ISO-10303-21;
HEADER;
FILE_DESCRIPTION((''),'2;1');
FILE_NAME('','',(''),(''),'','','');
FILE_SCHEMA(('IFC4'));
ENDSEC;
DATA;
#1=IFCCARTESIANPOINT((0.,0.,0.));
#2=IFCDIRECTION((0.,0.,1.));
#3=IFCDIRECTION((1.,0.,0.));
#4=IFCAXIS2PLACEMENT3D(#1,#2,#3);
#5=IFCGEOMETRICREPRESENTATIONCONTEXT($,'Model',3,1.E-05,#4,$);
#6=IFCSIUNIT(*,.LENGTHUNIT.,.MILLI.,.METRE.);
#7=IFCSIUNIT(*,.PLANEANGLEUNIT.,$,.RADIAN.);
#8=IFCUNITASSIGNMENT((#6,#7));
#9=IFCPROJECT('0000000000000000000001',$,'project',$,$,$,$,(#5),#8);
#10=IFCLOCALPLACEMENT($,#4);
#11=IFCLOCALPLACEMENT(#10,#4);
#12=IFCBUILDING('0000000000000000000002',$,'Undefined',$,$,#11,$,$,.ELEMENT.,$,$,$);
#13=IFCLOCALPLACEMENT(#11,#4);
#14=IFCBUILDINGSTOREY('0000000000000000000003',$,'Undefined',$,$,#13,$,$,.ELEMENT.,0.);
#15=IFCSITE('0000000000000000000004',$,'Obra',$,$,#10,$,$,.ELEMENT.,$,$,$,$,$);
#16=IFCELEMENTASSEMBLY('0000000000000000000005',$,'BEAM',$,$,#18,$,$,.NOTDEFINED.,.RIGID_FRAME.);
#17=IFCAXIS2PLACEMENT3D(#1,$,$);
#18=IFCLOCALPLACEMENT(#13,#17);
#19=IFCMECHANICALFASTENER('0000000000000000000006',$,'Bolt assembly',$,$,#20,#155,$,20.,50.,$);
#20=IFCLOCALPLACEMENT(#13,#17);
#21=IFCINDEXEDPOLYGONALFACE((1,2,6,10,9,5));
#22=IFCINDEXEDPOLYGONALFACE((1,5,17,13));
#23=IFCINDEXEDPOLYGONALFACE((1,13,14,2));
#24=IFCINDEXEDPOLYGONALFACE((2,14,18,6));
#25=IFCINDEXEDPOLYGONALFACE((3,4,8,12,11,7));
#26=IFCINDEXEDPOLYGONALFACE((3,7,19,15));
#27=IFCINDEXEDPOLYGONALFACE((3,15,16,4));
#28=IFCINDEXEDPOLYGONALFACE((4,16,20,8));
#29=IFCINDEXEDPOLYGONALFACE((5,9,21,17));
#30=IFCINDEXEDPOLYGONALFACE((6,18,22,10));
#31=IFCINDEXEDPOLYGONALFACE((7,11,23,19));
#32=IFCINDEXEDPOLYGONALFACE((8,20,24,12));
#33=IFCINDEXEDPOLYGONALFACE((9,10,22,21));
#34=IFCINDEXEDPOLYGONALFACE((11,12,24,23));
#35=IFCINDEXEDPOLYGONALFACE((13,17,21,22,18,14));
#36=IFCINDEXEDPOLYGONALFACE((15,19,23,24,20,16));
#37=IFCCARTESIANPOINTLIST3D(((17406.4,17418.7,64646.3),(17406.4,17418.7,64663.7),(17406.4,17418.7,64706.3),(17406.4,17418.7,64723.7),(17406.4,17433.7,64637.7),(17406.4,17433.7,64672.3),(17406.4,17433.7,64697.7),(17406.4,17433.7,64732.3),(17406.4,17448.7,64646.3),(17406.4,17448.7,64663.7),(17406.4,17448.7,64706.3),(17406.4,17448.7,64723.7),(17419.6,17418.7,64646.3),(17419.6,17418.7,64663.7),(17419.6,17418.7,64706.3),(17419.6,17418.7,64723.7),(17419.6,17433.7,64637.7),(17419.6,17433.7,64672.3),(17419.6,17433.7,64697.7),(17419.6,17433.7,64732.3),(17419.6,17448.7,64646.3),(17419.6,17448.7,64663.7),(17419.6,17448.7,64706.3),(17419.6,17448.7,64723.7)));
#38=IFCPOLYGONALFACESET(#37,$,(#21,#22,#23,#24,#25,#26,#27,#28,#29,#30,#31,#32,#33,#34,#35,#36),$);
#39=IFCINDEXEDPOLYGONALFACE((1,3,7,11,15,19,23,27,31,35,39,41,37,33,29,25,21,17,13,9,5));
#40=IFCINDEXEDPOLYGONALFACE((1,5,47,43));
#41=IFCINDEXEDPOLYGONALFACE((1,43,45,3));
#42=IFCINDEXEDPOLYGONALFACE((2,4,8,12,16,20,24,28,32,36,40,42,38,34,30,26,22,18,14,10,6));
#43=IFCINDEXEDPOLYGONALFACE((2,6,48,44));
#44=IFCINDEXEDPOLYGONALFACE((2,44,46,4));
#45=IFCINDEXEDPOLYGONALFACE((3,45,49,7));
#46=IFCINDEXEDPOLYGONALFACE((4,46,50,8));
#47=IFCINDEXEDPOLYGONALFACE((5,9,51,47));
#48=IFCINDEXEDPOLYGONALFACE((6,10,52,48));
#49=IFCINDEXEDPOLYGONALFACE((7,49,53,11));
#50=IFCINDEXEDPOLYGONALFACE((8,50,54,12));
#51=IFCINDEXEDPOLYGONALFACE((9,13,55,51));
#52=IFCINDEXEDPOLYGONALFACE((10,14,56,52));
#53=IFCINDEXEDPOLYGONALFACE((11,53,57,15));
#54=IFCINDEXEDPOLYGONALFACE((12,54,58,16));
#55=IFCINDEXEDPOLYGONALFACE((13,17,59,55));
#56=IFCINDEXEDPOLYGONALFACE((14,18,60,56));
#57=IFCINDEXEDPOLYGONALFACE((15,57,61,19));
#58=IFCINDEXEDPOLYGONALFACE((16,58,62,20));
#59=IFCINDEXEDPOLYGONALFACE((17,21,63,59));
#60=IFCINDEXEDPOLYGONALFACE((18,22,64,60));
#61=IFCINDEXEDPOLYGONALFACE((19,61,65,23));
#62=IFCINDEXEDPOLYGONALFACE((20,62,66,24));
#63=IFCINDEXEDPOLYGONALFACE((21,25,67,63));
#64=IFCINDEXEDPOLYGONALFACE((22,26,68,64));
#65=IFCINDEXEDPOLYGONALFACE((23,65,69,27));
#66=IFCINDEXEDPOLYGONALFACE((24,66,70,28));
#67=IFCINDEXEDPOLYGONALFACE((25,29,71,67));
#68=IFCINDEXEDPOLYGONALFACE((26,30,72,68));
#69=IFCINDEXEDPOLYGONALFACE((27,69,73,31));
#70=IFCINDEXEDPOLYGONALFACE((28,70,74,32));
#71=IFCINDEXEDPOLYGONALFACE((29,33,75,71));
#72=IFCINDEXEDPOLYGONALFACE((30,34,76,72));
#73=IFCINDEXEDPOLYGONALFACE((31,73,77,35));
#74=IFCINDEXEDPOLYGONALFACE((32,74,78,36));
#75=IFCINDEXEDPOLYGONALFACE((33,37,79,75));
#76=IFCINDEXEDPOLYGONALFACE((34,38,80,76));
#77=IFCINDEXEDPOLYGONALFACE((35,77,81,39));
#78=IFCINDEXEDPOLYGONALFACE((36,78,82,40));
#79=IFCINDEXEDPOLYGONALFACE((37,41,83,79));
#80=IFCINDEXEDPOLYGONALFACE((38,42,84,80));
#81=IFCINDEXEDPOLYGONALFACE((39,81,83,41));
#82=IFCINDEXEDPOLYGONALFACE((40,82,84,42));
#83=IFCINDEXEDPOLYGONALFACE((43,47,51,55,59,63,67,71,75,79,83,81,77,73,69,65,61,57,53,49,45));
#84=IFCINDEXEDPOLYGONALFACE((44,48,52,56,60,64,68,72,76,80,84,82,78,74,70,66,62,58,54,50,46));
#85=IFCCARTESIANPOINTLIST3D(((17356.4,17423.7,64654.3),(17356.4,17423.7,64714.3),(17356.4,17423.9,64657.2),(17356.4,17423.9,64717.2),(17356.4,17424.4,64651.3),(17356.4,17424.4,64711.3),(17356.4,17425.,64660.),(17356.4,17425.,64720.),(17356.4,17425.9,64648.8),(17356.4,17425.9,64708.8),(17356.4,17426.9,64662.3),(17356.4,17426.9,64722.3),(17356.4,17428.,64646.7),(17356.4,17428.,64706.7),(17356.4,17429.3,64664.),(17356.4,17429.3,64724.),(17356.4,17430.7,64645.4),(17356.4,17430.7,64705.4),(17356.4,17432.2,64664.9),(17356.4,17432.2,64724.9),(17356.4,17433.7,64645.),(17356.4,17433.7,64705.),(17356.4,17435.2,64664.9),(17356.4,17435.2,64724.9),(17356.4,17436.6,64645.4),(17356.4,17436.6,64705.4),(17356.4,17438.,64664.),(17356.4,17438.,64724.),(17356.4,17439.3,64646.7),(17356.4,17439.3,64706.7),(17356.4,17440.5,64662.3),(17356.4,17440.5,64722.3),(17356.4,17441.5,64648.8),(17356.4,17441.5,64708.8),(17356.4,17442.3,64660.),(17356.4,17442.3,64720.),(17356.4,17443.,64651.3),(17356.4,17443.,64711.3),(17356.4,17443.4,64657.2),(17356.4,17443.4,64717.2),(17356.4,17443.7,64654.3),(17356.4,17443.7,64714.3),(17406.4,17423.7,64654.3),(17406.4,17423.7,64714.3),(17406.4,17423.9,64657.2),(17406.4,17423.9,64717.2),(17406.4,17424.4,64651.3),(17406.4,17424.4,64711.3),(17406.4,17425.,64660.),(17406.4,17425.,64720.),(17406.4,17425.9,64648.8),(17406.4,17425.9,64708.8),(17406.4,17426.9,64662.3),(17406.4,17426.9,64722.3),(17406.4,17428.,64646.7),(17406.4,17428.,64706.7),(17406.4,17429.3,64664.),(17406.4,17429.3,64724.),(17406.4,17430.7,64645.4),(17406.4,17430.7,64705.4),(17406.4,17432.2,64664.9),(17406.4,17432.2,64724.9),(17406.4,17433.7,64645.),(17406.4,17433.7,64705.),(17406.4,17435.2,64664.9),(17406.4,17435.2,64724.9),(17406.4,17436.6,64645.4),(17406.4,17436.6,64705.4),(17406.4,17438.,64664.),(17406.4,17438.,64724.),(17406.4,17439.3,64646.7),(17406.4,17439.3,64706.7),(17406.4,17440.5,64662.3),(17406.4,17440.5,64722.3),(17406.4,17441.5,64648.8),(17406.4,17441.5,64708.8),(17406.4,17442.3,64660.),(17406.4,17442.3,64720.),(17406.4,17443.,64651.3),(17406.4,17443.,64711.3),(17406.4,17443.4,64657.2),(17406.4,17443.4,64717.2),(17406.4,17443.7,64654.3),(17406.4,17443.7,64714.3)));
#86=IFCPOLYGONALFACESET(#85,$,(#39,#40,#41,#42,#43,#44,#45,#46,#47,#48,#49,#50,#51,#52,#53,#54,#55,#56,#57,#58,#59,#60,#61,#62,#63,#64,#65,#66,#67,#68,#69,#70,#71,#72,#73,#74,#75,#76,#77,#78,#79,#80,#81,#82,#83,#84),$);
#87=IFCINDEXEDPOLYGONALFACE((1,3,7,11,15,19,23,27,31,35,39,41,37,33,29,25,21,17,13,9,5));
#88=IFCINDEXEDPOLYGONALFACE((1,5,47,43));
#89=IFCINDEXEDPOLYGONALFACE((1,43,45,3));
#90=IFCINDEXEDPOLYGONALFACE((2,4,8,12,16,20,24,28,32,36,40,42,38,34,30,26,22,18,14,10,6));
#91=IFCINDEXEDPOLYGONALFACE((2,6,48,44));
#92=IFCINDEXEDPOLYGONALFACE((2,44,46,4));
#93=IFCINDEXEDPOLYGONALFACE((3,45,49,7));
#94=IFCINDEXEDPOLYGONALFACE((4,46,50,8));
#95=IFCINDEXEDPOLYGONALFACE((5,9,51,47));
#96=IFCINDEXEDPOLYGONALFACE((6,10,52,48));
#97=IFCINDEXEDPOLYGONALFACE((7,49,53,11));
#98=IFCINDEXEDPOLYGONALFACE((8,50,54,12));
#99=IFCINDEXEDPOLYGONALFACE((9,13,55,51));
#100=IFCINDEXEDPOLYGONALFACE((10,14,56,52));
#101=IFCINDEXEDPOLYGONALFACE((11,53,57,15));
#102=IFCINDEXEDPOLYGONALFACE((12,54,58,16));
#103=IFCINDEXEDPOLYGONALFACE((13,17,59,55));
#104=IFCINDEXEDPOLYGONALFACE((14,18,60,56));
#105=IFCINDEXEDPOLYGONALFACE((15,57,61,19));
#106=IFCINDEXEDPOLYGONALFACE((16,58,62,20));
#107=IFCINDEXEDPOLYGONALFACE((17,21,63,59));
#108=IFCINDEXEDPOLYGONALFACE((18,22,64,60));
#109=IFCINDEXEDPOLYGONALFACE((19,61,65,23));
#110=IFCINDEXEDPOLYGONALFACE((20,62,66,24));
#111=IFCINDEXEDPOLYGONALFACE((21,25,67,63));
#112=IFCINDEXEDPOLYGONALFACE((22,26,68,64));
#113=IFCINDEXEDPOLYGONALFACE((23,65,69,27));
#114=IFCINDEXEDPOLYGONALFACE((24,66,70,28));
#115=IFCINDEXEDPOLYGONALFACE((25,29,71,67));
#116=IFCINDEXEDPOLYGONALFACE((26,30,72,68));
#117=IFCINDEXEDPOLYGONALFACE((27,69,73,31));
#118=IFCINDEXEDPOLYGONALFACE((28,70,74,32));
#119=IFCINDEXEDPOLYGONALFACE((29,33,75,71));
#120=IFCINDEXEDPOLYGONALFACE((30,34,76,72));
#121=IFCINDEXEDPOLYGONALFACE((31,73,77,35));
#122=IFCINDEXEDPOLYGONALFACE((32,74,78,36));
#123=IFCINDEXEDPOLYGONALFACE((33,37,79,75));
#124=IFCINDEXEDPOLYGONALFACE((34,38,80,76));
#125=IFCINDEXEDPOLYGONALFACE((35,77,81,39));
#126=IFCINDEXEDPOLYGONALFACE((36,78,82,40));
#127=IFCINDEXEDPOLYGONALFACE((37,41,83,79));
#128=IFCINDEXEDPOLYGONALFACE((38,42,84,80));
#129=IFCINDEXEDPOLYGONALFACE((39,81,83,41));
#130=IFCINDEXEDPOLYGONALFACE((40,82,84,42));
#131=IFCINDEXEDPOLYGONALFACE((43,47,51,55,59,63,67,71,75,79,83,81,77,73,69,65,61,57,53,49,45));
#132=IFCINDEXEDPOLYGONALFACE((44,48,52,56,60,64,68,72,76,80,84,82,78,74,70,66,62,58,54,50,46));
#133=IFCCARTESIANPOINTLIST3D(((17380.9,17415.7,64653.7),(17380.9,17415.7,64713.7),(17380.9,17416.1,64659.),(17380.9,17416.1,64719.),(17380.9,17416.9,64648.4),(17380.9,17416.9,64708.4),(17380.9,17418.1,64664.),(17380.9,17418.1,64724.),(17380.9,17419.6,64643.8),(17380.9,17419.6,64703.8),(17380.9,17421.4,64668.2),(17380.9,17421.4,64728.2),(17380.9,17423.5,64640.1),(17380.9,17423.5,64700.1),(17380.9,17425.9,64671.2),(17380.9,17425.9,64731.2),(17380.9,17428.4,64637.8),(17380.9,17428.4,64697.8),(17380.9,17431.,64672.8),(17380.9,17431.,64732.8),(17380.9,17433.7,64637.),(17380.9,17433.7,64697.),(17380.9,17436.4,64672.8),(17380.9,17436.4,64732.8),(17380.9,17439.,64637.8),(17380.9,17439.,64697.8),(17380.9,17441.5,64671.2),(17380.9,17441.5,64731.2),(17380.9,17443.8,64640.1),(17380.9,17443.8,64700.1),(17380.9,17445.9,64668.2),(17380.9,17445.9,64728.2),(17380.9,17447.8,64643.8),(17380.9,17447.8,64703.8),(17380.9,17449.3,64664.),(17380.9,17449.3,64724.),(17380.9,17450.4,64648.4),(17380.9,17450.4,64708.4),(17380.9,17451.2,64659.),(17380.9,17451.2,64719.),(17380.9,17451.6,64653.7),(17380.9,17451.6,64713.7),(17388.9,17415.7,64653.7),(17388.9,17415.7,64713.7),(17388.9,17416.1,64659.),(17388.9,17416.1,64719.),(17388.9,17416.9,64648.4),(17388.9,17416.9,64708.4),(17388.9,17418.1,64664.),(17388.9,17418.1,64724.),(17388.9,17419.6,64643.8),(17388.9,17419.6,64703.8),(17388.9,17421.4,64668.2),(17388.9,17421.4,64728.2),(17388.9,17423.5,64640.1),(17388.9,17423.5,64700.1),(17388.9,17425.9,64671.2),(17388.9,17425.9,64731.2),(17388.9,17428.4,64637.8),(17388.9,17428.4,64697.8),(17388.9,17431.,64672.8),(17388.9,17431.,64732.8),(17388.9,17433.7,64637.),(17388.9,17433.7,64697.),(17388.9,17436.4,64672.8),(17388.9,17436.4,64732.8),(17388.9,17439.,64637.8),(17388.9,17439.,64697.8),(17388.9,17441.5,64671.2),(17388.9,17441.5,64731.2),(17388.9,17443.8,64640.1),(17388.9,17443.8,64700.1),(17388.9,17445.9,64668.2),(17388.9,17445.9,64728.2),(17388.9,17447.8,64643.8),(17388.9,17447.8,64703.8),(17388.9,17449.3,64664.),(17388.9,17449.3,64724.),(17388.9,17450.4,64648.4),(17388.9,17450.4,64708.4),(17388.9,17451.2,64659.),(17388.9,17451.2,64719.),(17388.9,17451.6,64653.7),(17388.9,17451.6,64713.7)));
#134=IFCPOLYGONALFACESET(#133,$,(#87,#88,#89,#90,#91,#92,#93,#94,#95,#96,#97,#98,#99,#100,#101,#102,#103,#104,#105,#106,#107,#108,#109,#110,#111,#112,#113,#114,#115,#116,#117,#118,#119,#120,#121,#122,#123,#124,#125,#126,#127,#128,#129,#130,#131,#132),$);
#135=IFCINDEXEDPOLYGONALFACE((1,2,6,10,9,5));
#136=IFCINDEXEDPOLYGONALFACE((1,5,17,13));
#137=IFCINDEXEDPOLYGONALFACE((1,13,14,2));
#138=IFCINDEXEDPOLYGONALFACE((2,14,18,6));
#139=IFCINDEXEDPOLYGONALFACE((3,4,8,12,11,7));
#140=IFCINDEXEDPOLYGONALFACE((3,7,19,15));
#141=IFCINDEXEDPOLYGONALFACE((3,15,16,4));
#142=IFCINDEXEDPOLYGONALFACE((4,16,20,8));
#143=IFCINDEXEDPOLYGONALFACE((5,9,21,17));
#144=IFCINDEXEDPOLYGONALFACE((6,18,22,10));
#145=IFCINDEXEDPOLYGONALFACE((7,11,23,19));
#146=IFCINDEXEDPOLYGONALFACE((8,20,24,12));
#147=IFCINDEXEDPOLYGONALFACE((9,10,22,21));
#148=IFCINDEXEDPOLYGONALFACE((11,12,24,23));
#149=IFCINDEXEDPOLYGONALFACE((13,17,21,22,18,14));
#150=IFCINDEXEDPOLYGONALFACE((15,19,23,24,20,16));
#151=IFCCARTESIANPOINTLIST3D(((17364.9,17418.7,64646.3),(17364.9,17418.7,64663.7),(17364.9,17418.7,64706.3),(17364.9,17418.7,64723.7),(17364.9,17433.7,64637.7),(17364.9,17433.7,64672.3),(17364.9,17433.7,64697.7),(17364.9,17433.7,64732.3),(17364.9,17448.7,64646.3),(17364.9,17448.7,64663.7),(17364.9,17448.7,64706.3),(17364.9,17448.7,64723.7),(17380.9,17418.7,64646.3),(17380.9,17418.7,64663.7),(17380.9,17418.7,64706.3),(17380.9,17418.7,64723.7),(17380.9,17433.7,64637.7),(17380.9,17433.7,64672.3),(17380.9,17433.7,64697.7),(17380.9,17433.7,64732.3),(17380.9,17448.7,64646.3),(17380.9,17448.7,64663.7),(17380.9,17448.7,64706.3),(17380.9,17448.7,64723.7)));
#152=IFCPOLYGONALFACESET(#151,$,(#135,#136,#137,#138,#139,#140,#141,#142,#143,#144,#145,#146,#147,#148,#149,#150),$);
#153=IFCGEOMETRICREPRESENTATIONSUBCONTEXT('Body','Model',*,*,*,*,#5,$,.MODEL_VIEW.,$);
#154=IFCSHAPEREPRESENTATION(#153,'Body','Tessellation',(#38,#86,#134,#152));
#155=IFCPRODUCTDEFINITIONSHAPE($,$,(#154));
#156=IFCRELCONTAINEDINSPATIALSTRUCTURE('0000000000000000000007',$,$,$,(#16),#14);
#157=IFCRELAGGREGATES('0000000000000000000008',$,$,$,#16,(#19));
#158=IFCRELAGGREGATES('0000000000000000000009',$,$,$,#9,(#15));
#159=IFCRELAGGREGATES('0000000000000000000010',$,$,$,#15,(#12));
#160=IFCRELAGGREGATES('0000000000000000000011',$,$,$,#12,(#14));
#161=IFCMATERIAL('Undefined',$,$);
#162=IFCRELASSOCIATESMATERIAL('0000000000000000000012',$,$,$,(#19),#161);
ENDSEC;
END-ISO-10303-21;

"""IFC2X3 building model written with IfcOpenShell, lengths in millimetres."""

from ifc_helpers import new_model, si_unit, frame, origin_with_axes, origin_2d_with_axis, place, context, subcontext, project, spatial, polyline, circle, outline, extrude, source, transform, mapped, material, element, aggregate, save


model = new_model("IFC2X3")

# Units and contexts
model_context = context("Model", 3, precision=1e-05, world=origin_with_axes())
body_context = subcontext(model_context, "Body", "Model", "MODEL_VIEW")
ifc_project = project(units=[si_unit("LENGTHUNIT", "METRE", prefix="MILLI"), si_unit("PLANEANGLEUNIT", "RADIAN")], contexts=[model_context])

# Site, building, storey
site_placement = place(None, origin_with_axes())
site = spatial("IfcSite", under=ifc_project, at=site_placement, Name="Obra", CompositionType="ELEMENT")
building_placement = place(site_placement, origin_with_axes())
building = spatial("IfcBuilding", under=site, at=building_placement, Name="Undefined", CompositionType="ELEMENT")
storey_placement = place(building_placement, origin_with_axes())
storey = spatial("IfcBuildingStorey", under=building, at=storey_placement, Name="Undefined", CompositionType="ELEMENT", Elevation=0.0)

# Shared definitions
ifc_material = material(Name="Undefined")

# Element assembly, mechanical fastener
shared_shape_1 = source(origin_with_axes(), body_context, "Body", "SweptSolid", [
    extrude(outline(polyline([(17.3, 0.0), (8.7, 15.0), (-8.7, 15.0), (-17.3, 0.0), (-8.7, -15.0), (8.7, -15.0), (17.3, 0.0)])), frame((0.0, -27.0, 0.0), z_axis=(0.0, 1.0, 0.0), x_axis=(1.0, 0.0, 0.0)), (0.0, 0.0, 1.0), 13.2),
    extrude(circle(Radius=10.0, at=origin_2d_with_axis()), frame((0.0, -13.8, 0.0), z_axis=(0.0, 1.0, 0.0), x_axis=(1.0, 0.0, 0.0)), (0.0, 0.0, 1.0), 50.0),
    extrude(circle(Radius=18.0, at=origin_2d_with_axis()), frame((0.0, 3.7, 0.0), z_axis=(0.0, 1.0, 0.0), x_axis=(1.0, 0.0, 0.0)), (0.0, 0.0, 1.0), 8.0),
    extrude(outline(polyline([(17.3, 0.0), (8.7, 15.0), (-8.7, 15.0), (-17.3, 0.0), (-8.7, -15.0), (8.7, -15.0), (17.3, 0.0)])), frame((0.0, 11.7, 0.0), z_axis=(0.0, 1.0, 0.0), x_axis=(1.0, 0.0, 0.0)), (0.0, 0.0, 1.0), 16.0),
])
assembly_1_placement = place(storey_placement, origin_with_axes())
assembly_1 = element("IfcElementAssembly", 1, at=assembly_1_placement, inside=storey, Name="BEAM", AssemblyPlace="NOTDEFINED", PredefinedType="RIGID_FRAME")
mechanical_fastener_1_placement = place(assembly_1_placement, frame((17392.7, 17393.7, 64850.0), z_axis=(0.0, 1.0, 0.0), x_axis=(0.0, 0.0, -1.0)))
mechanical_fastener_1 = element("IfcMechanicalFastener", 2, at=mechanical_fastener_1_placement, material=ifc_material, Name="Bolt assembly", NominalDiameter=20.0, NominalLength=50.0, context=body_context, shape_type="MappedRepresentation", body=[
    mapped(shared_shape_1, transform((135.0, 0.0, 40.0))),
    mapped(shared_shape_1, transform((195.0, 0.0, 40.0))),
])

aggregate(assembly_1, [mechanical_fastener_1])

save(model, "model.ifc")
